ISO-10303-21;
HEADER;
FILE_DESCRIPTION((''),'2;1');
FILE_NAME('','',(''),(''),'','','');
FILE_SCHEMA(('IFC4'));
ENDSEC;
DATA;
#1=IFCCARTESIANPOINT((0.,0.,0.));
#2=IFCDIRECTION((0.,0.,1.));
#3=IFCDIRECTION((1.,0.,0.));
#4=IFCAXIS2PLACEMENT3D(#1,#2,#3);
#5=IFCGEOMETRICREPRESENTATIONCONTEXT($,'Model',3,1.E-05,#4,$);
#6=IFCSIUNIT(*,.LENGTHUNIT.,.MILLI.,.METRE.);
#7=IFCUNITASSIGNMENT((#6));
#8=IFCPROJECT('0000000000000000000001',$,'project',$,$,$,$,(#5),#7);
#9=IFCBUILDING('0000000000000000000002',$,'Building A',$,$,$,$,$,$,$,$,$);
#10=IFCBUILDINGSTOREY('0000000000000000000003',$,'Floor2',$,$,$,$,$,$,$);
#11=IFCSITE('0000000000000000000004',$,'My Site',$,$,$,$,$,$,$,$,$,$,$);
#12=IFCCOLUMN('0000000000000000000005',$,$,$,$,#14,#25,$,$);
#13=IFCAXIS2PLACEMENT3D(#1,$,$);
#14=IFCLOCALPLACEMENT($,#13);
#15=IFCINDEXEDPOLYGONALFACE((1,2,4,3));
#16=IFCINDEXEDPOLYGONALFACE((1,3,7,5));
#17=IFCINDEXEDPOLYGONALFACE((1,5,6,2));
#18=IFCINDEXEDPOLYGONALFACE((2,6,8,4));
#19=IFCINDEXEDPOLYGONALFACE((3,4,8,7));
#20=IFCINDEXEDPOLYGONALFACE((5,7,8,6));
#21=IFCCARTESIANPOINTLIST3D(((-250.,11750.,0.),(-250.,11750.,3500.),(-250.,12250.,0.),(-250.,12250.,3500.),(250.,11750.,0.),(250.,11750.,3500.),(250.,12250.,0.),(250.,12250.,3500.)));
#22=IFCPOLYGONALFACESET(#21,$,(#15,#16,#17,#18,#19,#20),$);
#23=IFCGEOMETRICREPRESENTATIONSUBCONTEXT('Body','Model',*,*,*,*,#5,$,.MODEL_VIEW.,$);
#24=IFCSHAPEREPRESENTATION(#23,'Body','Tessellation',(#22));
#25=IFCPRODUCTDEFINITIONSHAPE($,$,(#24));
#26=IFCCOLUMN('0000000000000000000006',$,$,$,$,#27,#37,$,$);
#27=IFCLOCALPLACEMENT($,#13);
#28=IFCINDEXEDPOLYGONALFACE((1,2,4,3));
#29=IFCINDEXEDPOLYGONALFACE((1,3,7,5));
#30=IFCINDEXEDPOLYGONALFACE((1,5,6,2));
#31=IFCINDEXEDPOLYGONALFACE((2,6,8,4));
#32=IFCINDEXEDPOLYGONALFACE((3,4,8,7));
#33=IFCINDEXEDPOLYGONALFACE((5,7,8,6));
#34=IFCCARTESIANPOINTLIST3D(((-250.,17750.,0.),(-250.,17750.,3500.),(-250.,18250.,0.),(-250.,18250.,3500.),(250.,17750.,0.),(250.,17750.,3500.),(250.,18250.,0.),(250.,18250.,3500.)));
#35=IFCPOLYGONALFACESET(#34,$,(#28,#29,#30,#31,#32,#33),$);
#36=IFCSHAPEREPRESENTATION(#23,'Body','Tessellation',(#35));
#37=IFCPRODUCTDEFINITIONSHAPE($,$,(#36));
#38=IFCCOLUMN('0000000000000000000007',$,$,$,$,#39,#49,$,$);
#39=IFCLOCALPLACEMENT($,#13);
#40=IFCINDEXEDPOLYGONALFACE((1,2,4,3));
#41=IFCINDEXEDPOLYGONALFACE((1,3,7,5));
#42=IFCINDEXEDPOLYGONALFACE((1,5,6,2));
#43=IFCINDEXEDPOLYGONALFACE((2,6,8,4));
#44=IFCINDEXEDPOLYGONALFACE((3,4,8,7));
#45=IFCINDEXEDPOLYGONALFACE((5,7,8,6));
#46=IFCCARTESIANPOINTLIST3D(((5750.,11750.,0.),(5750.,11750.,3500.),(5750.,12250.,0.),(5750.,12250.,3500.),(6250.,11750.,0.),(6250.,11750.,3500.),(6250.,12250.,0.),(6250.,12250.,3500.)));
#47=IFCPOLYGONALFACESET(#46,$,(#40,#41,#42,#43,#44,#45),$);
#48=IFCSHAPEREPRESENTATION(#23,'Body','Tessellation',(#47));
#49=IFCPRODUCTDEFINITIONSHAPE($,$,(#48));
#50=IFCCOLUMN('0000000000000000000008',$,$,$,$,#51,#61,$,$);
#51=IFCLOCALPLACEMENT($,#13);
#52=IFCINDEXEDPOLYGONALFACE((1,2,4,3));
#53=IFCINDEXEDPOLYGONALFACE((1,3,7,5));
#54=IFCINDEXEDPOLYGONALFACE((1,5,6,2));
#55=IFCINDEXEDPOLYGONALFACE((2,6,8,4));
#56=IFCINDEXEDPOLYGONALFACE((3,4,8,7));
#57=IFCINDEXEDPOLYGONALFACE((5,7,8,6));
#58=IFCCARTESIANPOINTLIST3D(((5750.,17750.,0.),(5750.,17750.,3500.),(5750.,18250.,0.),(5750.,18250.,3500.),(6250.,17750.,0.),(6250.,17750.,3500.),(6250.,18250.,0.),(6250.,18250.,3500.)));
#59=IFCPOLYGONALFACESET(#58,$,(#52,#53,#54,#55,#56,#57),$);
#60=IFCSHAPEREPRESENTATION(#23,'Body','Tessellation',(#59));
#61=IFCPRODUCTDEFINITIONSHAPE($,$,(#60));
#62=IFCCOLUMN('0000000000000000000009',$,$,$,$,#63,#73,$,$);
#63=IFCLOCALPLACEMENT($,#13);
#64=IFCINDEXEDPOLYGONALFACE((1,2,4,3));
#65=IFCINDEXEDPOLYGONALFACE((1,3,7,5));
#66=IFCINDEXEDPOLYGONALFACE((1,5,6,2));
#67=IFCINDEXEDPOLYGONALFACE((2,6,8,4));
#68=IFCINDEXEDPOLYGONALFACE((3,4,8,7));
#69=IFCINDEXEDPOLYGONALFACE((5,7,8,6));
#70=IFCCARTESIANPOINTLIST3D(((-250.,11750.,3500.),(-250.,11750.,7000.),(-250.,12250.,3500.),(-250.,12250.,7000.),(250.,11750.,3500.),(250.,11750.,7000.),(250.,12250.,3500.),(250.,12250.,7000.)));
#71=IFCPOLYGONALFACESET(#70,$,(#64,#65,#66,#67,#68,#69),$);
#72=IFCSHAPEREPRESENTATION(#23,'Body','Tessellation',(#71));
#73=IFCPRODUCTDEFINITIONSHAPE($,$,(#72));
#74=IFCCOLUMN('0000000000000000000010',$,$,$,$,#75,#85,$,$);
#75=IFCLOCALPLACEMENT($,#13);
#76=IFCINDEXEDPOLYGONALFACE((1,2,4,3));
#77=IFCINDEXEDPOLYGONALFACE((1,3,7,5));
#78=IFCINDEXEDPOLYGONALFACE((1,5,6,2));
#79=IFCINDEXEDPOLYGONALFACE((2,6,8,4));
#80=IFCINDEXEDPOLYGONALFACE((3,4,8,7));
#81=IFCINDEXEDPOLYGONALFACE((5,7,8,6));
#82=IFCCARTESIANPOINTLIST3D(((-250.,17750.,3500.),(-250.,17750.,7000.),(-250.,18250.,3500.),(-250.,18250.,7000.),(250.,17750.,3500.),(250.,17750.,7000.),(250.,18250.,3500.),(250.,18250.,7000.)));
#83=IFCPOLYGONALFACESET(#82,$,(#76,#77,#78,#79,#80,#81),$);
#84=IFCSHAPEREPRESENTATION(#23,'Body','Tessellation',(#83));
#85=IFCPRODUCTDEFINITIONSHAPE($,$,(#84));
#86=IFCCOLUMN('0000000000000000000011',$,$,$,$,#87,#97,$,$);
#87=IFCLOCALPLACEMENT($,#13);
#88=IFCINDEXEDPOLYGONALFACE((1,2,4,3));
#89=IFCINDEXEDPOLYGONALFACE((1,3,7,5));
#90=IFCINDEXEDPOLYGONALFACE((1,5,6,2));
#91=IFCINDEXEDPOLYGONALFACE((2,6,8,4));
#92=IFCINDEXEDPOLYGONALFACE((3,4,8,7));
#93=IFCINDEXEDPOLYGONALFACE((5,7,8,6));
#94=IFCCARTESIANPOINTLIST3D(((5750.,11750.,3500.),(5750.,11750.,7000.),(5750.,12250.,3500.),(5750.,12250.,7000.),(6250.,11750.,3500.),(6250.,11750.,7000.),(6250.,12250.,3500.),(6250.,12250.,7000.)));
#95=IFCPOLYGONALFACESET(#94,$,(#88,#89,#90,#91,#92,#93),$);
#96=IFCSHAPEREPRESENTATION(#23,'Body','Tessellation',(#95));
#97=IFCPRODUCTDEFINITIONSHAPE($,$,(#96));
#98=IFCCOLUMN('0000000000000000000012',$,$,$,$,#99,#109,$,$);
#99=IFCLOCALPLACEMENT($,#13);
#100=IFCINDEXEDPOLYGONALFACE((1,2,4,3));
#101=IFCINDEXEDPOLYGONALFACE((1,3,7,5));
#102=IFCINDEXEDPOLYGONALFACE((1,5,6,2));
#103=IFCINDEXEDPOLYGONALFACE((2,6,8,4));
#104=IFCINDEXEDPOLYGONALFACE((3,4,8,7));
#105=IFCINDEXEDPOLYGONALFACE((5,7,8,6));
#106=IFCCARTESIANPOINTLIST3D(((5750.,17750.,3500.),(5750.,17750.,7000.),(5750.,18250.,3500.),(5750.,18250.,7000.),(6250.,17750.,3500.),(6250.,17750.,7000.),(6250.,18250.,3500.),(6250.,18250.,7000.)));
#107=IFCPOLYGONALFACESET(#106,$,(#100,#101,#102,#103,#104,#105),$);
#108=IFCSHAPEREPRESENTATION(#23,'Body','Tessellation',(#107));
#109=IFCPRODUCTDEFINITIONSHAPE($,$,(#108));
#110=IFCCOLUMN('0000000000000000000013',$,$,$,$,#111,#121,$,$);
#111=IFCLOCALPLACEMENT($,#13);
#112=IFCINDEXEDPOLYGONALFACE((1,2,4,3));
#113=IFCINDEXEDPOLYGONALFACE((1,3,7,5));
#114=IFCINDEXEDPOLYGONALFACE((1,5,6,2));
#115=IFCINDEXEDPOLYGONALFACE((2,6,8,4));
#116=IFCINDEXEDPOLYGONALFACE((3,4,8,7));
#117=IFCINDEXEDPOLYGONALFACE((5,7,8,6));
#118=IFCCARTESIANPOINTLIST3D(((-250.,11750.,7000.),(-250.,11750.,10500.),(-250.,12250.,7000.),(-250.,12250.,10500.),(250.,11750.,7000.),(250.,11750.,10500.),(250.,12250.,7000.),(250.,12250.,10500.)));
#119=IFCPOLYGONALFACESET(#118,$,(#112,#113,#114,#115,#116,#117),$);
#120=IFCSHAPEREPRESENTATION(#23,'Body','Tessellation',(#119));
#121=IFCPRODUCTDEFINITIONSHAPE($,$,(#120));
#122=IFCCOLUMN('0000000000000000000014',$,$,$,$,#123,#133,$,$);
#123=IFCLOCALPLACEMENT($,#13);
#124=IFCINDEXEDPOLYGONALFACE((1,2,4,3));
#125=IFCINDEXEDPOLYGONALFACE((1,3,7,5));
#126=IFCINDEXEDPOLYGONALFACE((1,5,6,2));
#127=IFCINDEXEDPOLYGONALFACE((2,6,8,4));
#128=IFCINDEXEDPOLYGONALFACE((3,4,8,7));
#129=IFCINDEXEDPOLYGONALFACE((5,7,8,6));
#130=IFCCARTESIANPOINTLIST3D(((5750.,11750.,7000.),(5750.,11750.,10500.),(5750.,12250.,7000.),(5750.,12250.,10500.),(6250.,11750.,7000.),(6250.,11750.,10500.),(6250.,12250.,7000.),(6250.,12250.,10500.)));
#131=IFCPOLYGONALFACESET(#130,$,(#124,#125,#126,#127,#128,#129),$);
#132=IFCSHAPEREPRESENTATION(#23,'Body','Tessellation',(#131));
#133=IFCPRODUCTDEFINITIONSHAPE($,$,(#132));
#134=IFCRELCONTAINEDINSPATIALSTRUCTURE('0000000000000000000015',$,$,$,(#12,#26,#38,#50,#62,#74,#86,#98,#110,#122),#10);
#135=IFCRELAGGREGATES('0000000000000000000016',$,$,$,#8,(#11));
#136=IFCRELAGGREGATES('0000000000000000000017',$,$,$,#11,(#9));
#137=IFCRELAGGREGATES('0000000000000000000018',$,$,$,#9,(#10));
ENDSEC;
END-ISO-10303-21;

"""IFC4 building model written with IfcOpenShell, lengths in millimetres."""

from ifc_helpers import new_model, si_unit, frame, origin_with_axes, place, context, subcontext, project, spatial, line, indexed_curve, outline, extrude, element, save


model = new_model("IFC4")

# Units and contexts
model_context = context("Model", 3, precision=1e-05, world=origin_with_axes())
body_context = subcontext(model_context, "Body", "Model", "MODEL_VIEW")
ifc_project = project(units=[si_unit("LENGTHUNIT", "METRE", prefix="MILLI")], contexts=[model_context])

# Site, building, storey
site = spatial("IfcSite", under=ifc_project, Name="My Site")
building = spatial("IfcBuilding", under=site, Name="Building A")
storey = spatial("IfcBuildingStorey", under=building, Name="Floor2")

# Columns
for number, where, z_axis, x_axis in (
    (1, (0.0, 12000.0, 0.0), (0.0, 0.0, 1.0), (1.0, 0.0, 0.0)),
    (2, (0.0, 18000.0, 0.0), (0.0, 0.0, 1.0), (1.0, 0.0, 0.0)),
    (3, (6000.0, 12000.0, 0.0), (0.0, 0.0, 1.0), (1.0, 0.0, 0.0)),
    (4, (6000.0, 18000.0, 0.0), (0.0, 0.0, 1.0), (1.0, 0.0, 0.0)),
    (5, (0.0, 12000.0, 3500.0), (0.0, 0.0, 1.0), (1.0, 0.0, 0.0)),
    (6, (0.0, 18000.0, 3500.0), (0.0, 0.0, 1.0), (1.0, 0.0, 0.0)),
    (7, (6000.0, 12000.0, 3500.0), (0.0, 0.0, 1.0), (1.0, 0.0, 0.0)),
    (8, (6000.0, 18000.0, 3500.0), (0.0, 0.0, 1.0), (1.0, 0.0, 0.0)),
    (9, (0.0, 12000.0, 7000.0), (0.0, 0.0, 1.0), (1.0, 0.0, 0.0)),
    (10, (6000.0, 12000.0, 7000.0), (0.0, 0.0, 1.0), (1.0, 0.0, 0.0)),
):
    element("IfcColumn", number, at=place(None, frame(where, z_axis=z_axis, x_axis=x_axis)), inside=storey, context=body_context, shape_type="SweptSolid", body=[
        extrude(outline(indexed_curve([(-250.0, -250.0), (250.0, -250.0), (250.0, 250.0), (-250.0, 250.0)], segments=[line(1, 2, 3, 4, 1)])), origin_with_axes(), (0.0, 0.0, 1.0), 3500.0),
    ])

save(model, "model.ifc")
